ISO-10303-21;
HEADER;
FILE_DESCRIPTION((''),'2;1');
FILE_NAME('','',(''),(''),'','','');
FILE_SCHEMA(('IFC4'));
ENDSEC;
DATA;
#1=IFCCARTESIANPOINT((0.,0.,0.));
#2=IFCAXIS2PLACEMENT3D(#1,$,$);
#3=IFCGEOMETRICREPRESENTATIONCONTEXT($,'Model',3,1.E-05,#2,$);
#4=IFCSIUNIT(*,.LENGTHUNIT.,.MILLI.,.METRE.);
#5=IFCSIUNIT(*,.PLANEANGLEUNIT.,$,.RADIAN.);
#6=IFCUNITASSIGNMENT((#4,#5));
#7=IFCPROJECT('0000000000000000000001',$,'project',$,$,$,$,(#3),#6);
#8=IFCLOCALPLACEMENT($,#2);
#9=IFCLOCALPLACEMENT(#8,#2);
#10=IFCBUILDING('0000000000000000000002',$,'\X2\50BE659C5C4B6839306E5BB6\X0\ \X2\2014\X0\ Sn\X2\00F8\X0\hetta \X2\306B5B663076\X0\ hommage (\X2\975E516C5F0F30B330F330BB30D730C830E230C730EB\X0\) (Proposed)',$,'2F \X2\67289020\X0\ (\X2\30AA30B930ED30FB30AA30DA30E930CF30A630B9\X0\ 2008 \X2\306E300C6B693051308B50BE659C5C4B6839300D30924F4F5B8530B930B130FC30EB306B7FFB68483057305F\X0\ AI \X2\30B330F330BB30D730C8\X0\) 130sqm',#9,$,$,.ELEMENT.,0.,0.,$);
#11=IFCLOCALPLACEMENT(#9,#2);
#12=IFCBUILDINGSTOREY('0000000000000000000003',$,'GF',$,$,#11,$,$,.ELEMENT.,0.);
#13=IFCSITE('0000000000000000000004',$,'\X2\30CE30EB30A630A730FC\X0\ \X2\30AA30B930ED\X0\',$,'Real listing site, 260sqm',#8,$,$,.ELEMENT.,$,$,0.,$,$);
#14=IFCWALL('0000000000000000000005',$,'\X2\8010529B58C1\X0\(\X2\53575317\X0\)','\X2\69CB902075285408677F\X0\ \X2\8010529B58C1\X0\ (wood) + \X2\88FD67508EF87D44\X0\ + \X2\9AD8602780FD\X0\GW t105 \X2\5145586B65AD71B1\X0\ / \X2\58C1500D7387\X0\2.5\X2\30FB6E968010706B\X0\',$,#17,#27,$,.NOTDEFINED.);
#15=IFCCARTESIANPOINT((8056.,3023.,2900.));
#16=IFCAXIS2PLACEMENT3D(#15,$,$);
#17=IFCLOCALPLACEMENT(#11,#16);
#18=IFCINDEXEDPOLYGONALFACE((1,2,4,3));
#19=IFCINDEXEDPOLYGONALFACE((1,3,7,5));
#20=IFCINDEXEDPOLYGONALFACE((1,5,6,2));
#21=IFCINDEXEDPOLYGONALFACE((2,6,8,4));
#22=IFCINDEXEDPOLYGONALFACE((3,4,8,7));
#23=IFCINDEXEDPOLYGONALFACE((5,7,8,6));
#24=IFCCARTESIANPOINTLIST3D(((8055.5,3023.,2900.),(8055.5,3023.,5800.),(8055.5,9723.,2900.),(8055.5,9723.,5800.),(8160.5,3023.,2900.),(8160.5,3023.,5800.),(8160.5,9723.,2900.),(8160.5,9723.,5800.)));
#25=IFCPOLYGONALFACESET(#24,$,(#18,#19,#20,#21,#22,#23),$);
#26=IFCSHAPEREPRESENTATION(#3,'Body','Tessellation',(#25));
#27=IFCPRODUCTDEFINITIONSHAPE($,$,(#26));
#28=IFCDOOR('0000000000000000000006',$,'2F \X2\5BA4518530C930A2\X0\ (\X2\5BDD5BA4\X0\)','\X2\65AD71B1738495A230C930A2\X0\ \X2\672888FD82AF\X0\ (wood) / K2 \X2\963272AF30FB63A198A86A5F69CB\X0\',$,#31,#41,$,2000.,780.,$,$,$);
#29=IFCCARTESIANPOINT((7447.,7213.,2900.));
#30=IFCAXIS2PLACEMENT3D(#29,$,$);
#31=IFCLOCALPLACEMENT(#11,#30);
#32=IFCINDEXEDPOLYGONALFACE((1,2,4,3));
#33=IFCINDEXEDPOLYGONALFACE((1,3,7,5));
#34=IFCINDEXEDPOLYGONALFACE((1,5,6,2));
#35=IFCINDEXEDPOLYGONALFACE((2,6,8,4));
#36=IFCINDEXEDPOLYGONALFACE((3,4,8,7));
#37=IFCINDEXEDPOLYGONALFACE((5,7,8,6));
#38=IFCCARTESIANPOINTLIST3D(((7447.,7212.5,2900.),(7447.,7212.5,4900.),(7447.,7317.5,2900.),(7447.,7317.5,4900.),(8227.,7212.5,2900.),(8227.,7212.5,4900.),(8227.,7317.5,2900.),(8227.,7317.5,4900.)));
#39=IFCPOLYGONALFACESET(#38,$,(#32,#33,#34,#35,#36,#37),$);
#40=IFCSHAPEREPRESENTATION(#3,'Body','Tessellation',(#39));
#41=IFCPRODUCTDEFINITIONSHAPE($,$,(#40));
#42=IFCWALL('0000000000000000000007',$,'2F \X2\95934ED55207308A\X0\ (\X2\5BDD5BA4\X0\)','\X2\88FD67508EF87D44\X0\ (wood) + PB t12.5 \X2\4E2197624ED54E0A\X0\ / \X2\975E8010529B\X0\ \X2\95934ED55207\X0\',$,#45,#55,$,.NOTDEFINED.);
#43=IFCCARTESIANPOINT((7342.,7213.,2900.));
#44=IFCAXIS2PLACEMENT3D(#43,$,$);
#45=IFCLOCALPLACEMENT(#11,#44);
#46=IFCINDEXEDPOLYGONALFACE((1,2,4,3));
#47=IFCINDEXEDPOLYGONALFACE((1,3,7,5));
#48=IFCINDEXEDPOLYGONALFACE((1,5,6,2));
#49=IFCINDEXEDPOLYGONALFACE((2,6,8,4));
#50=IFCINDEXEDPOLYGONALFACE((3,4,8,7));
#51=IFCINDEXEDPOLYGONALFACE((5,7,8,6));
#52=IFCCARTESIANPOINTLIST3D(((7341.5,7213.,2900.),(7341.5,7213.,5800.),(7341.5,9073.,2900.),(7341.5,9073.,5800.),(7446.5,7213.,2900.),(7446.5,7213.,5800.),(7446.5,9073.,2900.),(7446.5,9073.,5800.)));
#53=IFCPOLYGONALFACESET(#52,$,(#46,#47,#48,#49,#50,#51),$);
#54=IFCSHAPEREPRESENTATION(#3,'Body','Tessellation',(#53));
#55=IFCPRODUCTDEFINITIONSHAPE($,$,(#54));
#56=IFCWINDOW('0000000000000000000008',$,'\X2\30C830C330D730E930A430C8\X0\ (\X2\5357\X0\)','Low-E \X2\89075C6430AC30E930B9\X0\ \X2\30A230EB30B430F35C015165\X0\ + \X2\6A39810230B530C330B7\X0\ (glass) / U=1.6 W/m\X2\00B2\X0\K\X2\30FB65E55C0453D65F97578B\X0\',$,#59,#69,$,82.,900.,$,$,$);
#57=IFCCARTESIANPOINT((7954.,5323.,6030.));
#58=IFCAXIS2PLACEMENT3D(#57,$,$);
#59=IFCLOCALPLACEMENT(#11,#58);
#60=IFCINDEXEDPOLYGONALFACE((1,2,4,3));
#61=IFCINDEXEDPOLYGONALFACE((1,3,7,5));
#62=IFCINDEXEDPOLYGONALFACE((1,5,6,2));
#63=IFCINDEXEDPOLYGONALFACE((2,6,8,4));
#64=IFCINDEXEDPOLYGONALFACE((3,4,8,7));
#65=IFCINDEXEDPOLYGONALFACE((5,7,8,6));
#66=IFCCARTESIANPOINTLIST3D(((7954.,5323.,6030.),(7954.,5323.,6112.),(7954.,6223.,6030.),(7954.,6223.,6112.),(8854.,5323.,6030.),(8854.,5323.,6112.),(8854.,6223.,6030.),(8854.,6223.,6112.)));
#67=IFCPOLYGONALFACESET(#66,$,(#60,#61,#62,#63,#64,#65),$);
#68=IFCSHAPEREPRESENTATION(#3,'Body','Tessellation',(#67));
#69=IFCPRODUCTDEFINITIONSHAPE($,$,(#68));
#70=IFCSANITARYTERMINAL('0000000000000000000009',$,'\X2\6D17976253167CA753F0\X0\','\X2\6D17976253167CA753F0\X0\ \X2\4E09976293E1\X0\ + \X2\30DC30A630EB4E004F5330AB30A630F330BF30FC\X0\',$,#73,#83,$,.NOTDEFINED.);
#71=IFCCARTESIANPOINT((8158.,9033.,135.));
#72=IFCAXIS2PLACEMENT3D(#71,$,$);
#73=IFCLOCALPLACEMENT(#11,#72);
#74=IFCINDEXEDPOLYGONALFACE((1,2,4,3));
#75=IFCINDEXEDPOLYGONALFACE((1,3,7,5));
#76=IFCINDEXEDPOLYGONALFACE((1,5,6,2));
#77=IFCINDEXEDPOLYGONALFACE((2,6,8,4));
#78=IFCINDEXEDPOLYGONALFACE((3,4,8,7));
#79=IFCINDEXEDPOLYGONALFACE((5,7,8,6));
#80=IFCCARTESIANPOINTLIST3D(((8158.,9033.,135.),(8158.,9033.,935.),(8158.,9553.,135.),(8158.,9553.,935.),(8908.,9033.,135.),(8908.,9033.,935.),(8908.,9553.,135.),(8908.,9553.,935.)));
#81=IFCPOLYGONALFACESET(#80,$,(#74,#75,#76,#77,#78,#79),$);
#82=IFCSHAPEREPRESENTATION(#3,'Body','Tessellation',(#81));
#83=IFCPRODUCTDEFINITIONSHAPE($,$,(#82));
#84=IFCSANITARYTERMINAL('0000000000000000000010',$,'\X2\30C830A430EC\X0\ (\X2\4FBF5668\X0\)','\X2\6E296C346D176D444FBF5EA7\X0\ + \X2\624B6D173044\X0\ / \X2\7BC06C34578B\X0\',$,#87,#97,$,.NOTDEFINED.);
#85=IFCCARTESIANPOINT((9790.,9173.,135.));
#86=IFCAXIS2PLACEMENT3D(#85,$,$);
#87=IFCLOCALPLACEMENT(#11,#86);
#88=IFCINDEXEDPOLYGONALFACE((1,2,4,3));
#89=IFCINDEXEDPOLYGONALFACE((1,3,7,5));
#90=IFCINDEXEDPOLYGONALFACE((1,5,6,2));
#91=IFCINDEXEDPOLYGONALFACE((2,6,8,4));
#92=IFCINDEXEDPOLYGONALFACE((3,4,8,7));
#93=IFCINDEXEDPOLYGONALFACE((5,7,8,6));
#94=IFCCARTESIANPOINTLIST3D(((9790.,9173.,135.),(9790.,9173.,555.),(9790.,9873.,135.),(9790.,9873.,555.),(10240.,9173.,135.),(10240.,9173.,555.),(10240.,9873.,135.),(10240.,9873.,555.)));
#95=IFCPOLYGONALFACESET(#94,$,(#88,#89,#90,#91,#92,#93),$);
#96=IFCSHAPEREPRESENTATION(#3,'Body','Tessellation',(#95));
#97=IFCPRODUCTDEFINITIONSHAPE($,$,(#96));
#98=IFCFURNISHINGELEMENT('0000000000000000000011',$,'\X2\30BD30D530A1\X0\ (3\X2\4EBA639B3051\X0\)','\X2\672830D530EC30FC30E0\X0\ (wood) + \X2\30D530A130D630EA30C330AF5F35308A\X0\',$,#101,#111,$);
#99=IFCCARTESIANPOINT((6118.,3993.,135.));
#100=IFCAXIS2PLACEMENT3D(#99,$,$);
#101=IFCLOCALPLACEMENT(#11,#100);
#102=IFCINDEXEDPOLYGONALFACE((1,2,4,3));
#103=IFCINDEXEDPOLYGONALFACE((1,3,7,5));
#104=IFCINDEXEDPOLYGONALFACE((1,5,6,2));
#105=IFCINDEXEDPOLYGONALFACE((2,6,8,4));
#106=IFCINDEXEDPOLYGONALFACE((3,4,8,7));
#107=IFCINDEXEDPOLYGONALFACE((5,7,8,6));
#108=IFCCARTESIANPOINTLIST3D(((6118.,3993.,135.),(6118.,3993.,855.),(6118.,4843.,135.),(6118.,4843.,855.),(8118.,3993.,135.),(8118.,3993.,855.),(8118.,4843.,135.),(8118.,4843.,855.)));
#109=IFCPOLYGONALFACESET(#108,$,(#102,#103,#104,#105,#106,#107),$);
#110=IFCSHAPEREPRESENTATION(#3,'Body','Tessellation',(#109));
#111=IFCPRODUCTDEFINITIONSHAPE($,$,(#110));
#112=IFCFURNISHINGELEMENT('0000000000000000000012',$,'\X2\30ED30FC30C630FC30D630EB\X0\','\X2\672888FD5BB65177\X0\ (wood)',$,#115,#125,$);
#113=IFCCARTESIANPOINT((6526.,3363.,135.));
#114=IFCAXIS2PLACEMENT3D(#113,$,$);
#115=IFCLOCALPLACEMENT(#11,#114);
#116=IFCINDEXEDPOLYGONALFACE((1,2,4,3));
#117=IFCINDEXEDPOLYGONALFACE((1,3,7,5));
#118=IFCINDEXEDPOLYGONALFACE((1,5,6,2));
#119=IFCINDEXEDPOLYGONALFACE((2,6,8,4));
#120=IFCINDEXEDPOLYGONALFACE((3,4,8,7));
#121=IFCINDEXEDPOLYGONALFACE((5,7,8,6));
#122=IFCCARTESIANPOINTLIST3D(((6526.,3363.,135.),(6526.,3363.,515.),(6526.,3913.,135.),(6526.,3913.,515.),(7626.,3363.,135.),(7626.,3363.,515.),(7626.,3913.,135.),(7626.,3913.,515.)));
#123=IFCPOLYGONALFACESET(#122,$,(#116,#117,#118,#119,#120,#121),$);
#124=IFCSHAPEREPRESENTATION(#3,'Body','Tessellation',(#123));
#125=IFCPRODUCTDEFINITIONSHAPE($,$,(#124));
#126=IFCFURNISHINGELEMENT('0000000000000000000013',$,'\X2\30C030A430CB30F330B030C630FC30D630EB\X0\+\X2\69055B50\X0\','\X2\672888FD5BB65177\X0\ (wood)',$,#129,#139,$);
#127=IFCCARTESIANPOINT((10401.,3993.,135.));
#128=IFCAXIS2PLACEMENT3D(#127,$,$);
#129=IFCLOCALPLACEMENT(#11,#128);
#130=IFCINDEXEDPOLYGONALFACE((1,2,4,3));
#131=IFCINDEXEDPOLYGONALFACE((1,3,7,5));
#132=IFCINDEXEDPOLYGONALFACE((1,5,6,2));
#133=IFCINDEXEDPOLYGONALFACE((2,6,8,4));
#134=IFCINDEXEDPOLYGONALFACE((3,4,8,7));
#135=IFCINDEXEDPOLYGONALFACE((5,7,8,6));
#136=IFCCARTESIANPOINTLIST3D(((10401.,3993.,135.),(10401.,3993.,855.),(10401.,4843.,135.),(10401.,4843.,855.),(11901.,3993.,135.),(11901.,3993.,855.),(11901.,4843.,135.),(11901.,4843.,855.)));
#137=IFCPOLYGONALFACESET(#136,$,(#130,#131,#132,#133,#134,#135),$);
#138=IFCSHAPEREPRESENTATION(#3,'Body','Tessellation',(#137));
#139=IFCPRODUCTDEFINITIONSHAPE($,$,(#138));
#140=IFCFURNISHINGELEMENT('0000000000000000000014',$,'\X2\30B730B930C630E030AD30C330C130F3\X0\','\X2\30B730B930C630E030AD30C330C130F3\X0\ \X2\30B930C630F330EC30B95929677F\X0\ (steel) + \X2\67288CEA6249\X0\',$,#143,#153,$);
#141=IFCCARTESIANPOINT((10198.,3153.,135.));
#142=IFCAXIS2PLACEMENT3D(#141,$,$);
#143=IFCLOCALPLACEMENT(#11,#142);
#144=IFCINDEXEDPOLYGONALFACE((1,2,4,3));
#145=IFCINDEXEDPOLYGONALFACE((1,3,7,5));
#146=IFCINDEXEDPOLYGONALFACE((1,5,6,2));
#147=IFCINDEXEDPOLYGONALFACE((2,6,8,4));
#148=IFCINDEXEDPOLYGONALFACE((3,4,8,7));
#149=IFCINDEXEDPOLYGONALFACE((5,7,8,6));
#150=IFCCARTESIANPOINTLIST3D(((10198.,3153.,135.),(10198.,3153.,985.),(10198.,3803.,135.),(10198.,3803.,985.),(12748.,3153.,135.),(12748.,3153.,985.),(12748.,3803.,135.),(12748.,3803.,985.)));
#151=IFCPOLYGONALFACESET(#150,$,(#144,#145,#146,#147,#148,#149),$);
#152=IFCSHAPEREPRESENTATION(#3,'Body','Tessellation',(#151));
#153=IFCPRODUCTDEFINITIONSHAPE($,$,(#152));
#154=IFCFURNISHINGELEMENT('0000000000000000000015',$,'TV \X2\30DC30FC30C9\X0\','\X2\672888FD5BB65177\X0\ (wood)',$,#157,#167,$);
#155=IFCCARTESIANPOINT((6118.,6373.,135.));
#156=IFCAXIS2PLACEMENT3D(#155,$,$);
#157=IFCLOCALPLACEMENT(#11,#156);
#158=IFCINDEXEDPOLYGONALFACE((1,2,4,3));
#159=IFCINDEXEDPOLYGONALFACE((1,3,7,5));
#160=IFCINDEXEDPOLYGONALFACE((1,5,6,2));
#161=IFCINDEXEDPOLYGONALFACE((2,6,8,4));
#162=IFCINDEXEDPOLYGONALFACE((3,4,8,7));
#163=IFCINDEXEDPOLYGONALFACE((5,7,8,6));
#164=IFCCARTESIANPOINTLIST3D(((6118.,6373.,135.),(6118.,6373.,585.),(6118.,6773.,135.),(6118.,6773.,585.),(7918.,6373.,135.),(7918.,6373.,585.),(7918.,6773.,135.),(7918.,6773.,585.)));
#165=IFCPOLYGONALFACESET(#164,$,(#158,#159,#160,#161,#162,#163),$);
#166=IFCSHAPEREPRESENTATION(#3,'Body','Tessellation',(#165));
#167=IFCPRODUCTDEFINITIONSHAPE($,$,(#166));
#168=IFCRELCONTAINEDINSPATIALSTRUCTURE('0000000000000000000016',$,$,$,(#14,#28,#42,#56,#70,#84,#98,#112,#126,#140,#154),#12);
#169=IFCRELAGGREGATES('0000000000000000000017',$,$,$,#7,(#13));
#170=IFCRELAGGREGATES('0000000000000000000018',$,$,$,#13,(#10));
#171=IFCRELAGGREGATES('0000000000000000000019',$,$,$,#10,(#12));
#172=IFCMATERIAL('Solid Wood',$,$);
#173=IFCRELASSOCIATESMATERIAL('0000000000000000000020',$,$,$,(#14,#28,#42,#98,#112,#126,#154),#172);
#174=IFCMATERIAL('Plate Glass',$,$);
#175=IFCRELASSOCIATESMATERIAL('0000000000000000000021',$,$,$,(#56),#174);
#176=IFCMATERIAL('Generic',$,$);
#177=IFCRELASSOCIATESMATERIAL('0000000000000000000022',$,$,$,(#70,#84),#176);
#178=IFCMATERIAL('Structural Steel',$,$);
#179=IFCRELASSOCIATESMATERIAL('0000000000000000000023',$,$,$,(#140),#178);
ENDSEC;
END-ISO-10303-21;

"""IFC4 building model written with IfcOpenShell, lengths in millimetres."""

from ifc_helpers import new_model, si_unit, frame, frame_2d, origin, place, context, project, spatial, rectangle, extrude, material, element, fill, save


model = new_model("IFC4")

# Units and contexts
model_context = context("Model", 3, precision=1e-05, world=origin())
ifc_project = project(units=[si_unit("LENGTHUNIT", "METRE", prefix="MILLI"), si_unit("PLANEANGLEUNIT", "RADIAN")], contexts=[model_context])

# Site, building, storey
site_placement = place(None, origin())
site = spatial("IfcSite", under=ifc_project, at=site_placement, Name="ノルウェー オスロ", ObjectType="Real listing site, 260sqm", CompositionType="ELEMENT", RefElevation=0.0)
building_placement = place(site_placement, origin())
building = spatial("IfcBuilding", under=site, at=building_placement, Name="傾斜屋根の家 — Snøhetta に学ぶ hommage (非公式コンセプトモデル) (Proposed)", ObjectType="2F 木造 (オスロ・オペラハウス 2008 の「歩ける傾斜屋根」を住宅スケールに翻案した AI コンセプト) 130sqm", CompositionType="ELEMENT", ElevationOfRefHeight=0.0, ElevationOfTerrain=0.0)
storey_placement = place(building_placement, origin())
storey = spatial("IfcBuildingStorey", under=building, at=storey_placement, Name="GF", CompositionType="ELEMENT", Elevation=0.0)

# Shared definitions
ifc_material_1 = material(Name="Solid Wood")

# Wall, opening, door
wall_1_placement = place(storey_placement, frame((8056.0, 3023.0, 2900.0)))
wall_1 = element("IfcWall", 1, at=wall_1_placement, inside=storey, material=ifc_material_1, Name="耐力壁(南北)", Description="構造用合板 耐力壁 (wood) + 製材軸組 + 高性能GW t105 充填断熱 / 壁倍率2.5・準耐火", PredefinedType="NOTDEFINED", context=model_context, shape_type="SweptSolid", body=[
    extrude(rectangle(XDim=105.0, YDim=6700.0, at=frame_2d((52.0, 3350.0))), frame((8056.0, 3023.0, 2900.0)), (0.0, 0.0, 1.0), 2900.0),
])
opening_1_placement = place(storey_placement, frame((7447.0, 7213.0, 2900.0)))
opening_1 = element("IfcOpeningElement", 2, at=opening_1_placement, cuts=wall_1, PredefinedType="NOTDEFINED", context=model_context, shape_type="SweptSolid", body=[
    extrude(rectangle(XDim=780.0, YDim=105.0, at=frame_2d((390.0, 52.0))), frame((7447.0, 7213.0, 2900.0)), (0.0, 0.0, 1.0), 2000.0),
])
door_1_placement = place(storey_placement, frame((7447.0, 7213.0, 2900.0)))
door_1 = element("IfcDoor", 3, at=door_1_placement, inside=storey, material=ifc_material_1, Name="2F 室内ドア (寝室)", Description="断熱玄関ドア 木製芯 (wood) / K2 防犯・採風機構", OverallHeight=2000.0, OverallWidth=780.0, context=model_context, shape_type="SweptSolid", body=[
    extrude(rectangle(XDim=780.0, YDim=105.0, at=frame_2d((390.0, 52.0))), frame((7447.0, 7213.0, 2900.0)), (0.0, 0.0, 1.0), 2000.0),
])
fill(opening_1, door_1)

# Wall
wall_2_placement = place(storey_placement, frame((7342.0, 7213.0, 2900.0)))
element("IfcWall", 4, at=wall_2_placement, inside=storey, material=ifc_material_1, Name="2F 間仕切り (寝室)", Description="製材軸組 (wood) + PB t12.5 両面仕上 / 非耐力 間仕切", PredefinedType="NOTDEFINED", context=model_context, shape_type="SweptSolid", body=[
    extrude(rectangle(XDim=105.0, YDim=1860.0, at=frame_2d((52.0, 930.0))), frame((7342.0, 7213.0, 2900.0)), (0.0, 0.0, 1.0), 2900.0),
])

# Window
ifc_material_2 = material(Name="Plate Glass")
window_placement = place(storey_placement, frame((7954.0, 5323.0, 6030.0)))
element("IfcWindow", 5, at=window_placement, inside=storey, material=ifc_material_2, Name="トップライト (南)", Description="Low-E 複層ガラス アルゴン封入 + 樹脂サッシ (glass) / U=1.6 W/m²K・日射取得型", OverallHeight=82.0, OverallWidth=900.0, context=model_context, shape_type="SweptSolid", body=[
    extrude(rectangle(XDim=900.0, YDim=900.0, at=frame_2d((450.0, 450.0))), frame((7954.0, 5323.0, 6030.0)), (0.0, 0.0, 1.0), 82.0),
])

# Sanitary terminals
ifc_material_3 = material(Name="Generic")
sanitary_terminal_1_placement = place(storey_placement, frame((8158.0, 9033.0, 135.0)))
element("IfcSanitaryTerminal", 6, at=sanitary_terminal_1_placement, inside=storey, material=ifc_material_3, Name="洗面化粧台", Description="洗面化粧台 三面鏡 + ボウル一体カウンター", PredefinedType="NOTDEFINED", context=model_context, shape_type="SweptSolid", body=[
    extrude(rectangle(XDim=750.0, YDim=520.0, at=frame_2d((375.0, 260.0))), frame((8158.0, 9033.0, 135.0)), (0.0, 0.0, 1.0), 800.0),
])
sanitary_terminal_2_placement = place(storey_placement, frame((9790.0, 9173.0, 135.0)))
element("IfcSanitaryTerminal", 7, at=sanitary_terminal_2_placement, inside=storey, material=ifc_material_3, Name="トイレ (便器)", Description="温水洗浄便座 + 手洗い / 節水型", PredefinedType="NOTDEFINED", context=model_context, shape_type="SweptSolid", body=[
    extrude(rectangle(XDim=450.0, YDim=700.0, at=frame_2d((225.0, 350.0))), frame((9790.0, 9173.0, 135.0)), (0.0, 0.0, 1.0), 420.0),
])

# Furnishing elements
furnishing_1_placement = place(storey_placement, frame((6118.0, 3993.0, 135.0)))
element("IfcFurnishingElement", 8, at=furnishing_1_placement, inside=storey, material=ifc_material_1, Name="ソファ (3人掛け)", Description="木フレーム (wood) + ファブリック張り", context=model_context, shape_type="SweptSolid", body=[
    extrude(rectangle(XDim=2000.0, YDim=850.0, at=frame_2d((1000.0, 425.0))), frame((6118.0, 3993.0, 135.0)), (0.0, 0.0, 1.0), 720.0),
])
furnishing_2_placement = place(storey_placement, frame((6526.0, 3363.0, 135.0)))
element("IfcFurnishingElement", 9, at=furnishing_2_placement, inside=storey, material=ifc_material_1, Name="ローテーブル", Description="木製家具 (wood)", context=model_context, shape_type="SweptSolid", body=[
    extrude(rectangle(XDim=1100.0, YDim=550.0, at=frame_2d((550.0, 275.0))), frame((6526.0, 3363.0, 135.0)), (0.0, 0.0, 1.0), 380.0),
])
furnishing_3_placement = place(storey_placement, frame((10401.0, 3993.0, 135.0)))
element("IfcFurnishingElement", 10, at=furnishing_3_placement, inside=storey, material=ifc_material_1, Name="ダイニングテーブル+椅子", Description="木製家具 (wood)", context=model_context, shape_type="SweptSolid", body=[
    extrude(rectangle(XDim=1500.0, YDim=850.0, at=frame_2d((750.0, 425.0))), frame((10401.0, 3993.0, 135.0)), (0.0, 0.0, 1.0), 720.0),
])
ifc_material_4 = material(Name="Structural Steel")
furnishing_4_placement = place(storey_placement, frame((10198.0, 3153.0, 135.0)))
element("IfcFurnishingElement", 11, at=furnishing_4_placement, inside=storey, material=ifc_material_4, Name="システムキッチン", Description="システムキッチン ステンレス天板 (steel) + 木質扉", context=model_context, shape_type="SweptSolid", body=[
    extrude(rectangle(XDim=2550.0, YDim=650.0, at=frame_2d((1275.0, 325.0))), frame((10198.0, 3153.0, 135.0)), (0.0, 0.0, 1.0), 850.0),
])
furnishing_5_placement = place(storey_placement, frame((6118.0, 6373.0, 135.0)))
element("IfcFurnishingElement", 12, at=furnishing_5_placement, inside=storey, material=ifc_material_1, Name="TV ボード", Description="木製家具 (wood)", context=model_context, shape_type="SweptSolid", body=[
    extrude(rectangle(XDim=1800.0, YDim=400.0, at=frame_2d((900.0, 200.0))), frame((6118.0, 6373.0, 135.0)), (0.0, 0.0, 1.0), 450.0),
])

save(model, "model.ifc")
